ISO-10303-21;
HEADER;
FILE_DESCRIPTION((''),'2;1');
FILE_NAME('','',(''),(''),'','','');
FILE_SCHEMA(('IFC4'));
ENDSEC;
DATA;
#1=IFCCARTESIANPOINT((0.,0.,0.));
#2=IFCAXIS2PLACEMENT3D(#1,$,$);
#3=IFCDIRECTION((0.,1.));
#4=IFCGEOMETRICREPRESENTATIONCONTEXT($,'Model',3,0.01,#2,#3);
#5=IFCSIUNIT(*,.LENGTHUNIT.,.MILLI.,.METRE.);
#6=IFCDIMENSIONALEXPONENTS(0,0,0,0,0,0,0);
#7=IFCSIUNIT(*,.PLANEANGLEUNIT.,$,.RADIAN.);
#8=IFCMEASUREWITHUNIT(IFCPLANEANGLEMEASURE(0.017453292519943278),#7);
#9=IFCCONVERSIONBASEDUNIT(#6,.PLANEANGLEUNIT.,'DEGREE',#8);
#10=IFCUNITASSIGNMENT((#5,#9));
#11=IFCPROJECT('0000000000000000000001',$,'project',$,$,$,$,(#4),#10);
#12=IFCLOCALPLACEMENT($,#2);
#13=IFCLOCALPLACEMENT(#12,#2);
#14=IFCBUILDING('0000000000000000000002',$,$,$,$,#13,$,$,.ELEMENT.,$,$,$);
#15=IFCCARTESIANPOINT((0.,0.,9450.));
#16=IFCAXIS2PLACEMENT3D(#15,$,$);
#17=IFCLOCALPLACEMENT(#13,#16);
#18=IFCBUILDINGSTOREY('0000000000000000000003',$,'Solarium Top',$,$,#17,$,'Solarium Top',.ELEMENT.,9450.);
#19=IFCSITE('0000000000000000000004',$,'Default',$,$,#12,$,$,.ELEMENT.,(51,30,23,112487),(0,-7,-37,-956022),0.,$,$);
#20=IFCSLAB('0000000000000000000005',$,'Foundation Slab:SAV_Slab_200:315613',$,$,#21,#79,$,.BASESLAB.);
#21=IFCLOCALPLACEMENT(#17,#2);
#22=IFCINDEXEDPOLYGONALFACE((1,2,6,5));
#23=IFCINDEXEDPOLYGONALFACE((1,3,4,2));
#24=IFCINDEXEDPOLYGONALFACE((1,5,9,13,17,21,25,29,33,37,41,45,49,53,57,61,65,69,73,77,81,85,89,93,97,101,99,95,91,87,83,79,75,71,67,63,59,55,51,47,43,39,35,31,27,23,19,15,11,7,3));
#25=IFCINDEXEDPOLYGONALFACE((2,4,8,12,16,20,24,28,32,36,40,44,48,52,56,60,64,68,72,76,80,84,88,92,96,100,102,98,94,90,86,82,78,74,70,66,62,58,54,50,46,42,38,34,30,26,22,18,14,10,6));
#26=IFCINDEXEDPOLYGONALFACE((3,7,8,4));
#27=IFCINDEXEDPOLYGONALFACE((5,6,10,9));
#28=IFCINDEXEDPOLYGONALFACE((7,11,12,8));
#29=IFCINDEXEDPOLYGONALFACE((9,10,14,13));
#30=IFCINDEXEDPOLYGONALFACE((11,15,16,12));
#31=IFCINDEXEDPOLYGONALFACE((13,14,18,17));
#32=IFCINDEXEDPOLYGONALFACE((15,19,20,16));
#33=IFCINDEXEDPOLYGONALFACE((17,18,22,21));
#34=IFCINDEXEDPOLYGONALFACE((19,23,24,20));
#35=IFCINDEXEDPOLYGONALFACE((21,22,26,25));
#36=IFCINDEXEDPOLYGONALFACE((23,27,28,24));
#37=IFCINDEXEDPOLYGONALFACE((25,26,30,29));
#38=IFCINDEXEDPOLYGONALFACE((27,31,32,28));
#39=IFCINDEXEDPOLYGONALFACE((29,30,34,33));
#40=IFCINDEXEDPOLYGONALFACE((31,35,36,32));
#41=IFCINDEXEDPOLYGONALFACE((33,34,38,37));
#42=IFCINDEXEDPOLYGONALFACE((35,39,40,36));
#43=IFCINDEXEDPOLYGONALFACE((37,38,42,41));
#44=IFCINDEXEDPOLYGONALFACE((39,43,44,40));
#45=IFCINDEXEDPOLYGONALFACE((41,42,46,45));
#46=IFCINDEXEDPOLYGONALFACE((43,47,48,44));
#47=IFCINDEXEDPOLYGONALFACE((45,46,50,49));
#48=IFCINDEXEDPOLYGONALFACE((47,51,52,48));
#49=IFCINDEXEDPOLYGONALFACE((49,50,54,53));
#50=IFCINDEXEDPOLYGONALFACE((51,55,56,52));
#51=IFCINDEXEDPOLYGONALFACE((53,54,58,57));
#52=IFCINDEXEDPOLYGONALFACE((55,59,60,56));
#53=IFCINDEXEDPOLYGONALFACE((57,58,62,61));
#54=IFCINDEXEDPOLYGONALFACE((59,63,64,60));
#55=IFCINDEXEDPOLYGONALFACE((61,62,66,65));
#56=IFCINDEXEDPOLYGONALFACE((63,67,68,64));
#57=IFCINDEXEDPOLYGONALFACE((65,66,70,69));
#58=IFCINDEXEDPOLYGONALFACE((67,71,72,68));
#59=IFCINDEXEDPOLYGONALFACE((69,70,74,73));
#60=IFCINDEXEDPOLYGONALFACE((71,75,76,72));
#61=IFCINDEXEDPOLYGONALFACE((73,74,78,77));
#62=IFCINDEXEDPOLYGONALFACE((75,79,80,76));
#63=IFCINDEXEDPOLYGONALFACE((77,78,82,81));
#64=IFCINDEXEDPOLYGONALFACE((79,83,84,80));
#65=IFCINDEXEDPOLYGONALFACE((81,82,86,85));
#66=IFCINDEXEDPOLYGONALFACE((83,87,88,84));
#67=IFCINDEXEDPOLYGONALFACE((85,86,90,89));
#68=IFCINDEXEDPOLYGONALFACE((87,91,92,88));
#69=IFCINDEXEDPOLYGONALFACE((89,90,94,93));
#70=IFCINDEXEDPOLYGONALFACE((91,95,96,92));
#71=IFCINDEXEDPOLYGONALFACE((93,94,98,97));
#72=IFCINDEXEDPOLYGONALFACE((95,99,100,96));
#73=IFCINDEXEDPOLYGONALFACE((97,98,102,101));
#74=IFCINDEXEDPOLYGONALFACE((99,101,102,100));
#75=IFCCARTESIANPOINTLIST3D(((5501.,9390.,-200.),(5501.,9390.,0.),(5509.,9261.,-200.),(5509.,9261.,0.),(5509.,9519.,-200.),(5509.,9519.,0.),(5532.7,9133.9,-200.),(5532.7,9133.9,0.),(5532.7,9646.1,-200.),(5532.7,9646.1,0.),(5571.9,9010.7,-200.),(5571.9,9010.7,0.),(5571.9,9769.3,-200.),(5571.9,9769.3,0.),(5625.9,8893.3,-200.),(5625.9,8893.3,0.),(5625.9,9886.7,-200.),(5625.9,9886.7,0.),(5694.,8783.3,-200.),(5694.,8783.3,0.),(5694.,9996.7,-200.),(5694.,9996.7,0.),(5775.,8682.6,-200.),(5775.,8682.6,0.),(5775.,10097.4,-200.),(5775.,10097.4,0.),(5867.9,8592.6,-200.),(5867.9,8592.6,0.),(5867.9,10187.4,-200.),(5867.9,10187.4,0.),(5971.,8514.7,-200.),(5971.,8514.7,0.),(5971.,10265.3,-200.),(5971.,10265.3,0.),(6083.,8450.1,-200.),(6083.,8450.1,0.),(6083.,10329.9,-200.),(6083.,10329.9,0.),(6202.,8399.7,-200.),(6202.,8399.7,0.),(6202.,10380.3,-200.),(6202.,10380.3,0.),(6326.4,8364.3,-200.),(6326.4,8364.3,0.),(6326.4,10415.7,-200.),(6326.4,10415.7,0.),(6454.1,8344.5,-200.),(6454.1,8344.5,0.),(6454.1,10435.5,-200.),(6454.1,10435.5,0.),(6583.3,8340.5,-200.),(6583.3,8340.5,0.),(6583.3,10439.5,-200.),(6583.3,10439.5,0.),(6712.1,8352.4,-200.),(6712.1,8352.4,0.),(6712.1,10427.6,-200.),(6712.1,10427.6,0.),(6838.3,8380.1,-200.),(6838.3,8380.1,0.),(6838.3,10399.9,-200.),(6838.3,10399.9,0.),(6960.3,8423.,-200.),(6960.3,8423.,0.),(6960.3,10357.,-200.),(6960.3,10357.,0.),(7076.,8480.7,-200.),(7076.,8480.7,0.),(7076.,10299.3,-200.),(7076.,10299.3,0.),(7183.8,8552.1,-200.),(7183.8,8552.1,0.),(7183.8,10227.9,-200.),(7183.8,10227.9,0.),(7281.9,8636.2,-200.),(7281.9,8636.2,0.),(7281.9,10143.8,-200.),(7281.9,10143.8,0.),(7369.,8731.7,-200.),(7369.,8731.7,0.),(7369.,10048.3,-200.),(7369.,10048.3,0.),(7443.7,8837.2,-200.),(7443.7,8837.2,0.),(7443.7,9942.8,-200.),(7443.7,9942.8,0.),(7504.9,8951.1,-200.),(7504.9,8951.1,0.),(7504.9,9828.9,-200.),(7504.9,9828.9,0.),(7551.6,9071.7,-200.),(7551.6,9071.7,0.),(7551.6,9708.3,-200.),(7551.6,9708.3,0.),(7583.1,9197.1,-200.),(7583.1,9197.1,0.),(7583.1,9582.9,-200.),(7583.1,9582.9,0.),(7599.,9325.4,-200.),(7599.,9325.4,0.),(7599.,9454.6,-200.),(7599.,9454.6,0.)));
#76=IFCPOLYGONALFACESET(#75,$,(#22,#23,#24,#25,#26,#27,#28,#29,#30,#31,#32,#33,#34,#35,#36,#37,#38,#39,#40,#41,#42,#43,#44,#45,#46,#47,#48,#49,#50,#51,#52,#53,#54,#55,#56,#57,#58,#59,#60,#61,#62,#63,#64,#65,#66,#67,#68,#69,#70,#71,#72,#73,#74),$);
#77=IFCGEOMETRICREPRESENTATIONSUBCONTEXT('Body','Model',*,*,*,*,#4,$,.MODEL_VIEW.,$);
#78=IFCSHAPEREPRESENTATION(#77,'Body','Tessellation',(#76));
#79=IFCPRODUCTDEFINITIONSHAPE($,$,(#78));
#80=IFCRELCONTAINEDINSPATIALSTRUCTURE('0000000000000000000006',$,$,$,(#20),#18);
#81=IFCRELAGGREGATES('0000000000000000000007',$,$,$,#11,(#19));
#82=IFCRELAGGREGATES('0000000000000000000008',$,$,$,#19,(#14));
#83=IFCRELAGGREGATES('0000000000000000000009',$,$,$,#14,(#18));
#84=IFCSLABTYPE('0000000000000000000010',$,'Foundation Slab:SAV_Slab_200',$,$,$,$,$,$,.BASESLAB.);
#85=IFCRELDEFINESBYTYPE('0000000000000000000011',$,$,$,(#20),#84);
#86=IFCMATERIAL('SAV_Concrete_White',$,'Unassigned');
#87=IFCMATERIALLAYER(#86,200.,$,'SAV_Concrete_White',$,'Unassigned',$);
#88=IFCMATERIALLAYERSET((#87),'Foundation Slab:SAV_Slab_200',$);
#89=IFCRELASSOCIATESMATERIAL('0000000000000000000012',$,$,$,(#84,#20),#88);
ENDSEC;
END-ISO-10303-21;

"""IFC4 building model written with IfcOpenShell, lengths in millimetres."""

from ifc_helpers import new_model, entity, si_unit, converted_unit, direction, frame, frame_2d, origin, place, context, subcontext, project, spatial, circle, extrude, material, layer, layer_set, layer_usage, type_object, element, save


model = new_model("IFC4")

# Units and contexts
model_context = context("Model", 3, precision=0.01, world=origin(), true_north=direction((0.0, 1.0)))
body_context = subcontext(model_context, "Body", "Model", "MODEL_VIEW")
ifc_project = project(units=[si_unit("LENGTHUNIT", "METRE", prefix="MILLI"), converted_unit("PLANEANGLEUNIT", "DEGREE", entity("IfcPlaneAngleMeasure", 0.017453292519943278), si_unit("PLANEANGLEUNIT", "RADIAN"), dimensions=[0, 0, 0, 0, 0, 0, 0])], contexts=[model_context])

# Site, building, storey
site_placement = place(None, origin())
site = spatial("IfcSite", under=ifc_project, at=site_placement, Name="Default", CompositionType="ELEMENT", RefLatitude=(51, 30, 23, 112487), RefLongitude=(0, -7, -37, -956022), RefElevation=0.0)
building_placement = place(site_placement, origin())
building = spatial("IfcBuilding", under=site, at=building_placement, CompositionType="ELEMENT")
storey_placement = place(building_placement, frame((0.0, 0.0, 9450.0)))
storey = spatial("IfcBuildingStorey", under=building, at=storey_placement, Name="Solarium Top", LongName="Solarium Top", CompositionType="ELEMENT", Elevation=9450.0)

# Slab
ifc_material = material(Name="SAV_Concrete_White", Category="Unassigned")
ifc_layer = layer(ifc_material, 200.0, Name="SAV_Concrete_White", Category="Unassigned")
ifc_layer_set = layer_set([ifc_layer], Name="Foundation Slab:SAV_Slab_200")
ifc_layer_usage = layer_usage(ifc_layer_set, "AXIS3", "POSITIVE", 0.0)
slab_type = type_object("IfcSlabType", Name="Foundation Slab:SAV_Slab_200", PredefinedType="BASESLAB", material=ifc_layer_set)
slab_placement = place(storey_placement, origin())
element("IfcSlab", 1, at=slab_placement, inside=storey, type_object=slab_type, material=ifc_layer_usage, Name="Foundation Slab:SAV_Slab_200:315613", PredefinedType="BASESLAB", context=body_context, shape_type="SweptSolid", body=[
    extrude(circle(Radius=1050.0, at=frame_2d((0.0, 0.0), x_axis=(1.0, 0.0))), frame((6551.0, 9390.0, 0.0), z_axis=(0.0, 0.0, -1.0), x_axis=(-1.0, 0.0, 0.0)), (0.0, 0.0, 1.0), 200.0),
])

save(model, "model.ifc")
